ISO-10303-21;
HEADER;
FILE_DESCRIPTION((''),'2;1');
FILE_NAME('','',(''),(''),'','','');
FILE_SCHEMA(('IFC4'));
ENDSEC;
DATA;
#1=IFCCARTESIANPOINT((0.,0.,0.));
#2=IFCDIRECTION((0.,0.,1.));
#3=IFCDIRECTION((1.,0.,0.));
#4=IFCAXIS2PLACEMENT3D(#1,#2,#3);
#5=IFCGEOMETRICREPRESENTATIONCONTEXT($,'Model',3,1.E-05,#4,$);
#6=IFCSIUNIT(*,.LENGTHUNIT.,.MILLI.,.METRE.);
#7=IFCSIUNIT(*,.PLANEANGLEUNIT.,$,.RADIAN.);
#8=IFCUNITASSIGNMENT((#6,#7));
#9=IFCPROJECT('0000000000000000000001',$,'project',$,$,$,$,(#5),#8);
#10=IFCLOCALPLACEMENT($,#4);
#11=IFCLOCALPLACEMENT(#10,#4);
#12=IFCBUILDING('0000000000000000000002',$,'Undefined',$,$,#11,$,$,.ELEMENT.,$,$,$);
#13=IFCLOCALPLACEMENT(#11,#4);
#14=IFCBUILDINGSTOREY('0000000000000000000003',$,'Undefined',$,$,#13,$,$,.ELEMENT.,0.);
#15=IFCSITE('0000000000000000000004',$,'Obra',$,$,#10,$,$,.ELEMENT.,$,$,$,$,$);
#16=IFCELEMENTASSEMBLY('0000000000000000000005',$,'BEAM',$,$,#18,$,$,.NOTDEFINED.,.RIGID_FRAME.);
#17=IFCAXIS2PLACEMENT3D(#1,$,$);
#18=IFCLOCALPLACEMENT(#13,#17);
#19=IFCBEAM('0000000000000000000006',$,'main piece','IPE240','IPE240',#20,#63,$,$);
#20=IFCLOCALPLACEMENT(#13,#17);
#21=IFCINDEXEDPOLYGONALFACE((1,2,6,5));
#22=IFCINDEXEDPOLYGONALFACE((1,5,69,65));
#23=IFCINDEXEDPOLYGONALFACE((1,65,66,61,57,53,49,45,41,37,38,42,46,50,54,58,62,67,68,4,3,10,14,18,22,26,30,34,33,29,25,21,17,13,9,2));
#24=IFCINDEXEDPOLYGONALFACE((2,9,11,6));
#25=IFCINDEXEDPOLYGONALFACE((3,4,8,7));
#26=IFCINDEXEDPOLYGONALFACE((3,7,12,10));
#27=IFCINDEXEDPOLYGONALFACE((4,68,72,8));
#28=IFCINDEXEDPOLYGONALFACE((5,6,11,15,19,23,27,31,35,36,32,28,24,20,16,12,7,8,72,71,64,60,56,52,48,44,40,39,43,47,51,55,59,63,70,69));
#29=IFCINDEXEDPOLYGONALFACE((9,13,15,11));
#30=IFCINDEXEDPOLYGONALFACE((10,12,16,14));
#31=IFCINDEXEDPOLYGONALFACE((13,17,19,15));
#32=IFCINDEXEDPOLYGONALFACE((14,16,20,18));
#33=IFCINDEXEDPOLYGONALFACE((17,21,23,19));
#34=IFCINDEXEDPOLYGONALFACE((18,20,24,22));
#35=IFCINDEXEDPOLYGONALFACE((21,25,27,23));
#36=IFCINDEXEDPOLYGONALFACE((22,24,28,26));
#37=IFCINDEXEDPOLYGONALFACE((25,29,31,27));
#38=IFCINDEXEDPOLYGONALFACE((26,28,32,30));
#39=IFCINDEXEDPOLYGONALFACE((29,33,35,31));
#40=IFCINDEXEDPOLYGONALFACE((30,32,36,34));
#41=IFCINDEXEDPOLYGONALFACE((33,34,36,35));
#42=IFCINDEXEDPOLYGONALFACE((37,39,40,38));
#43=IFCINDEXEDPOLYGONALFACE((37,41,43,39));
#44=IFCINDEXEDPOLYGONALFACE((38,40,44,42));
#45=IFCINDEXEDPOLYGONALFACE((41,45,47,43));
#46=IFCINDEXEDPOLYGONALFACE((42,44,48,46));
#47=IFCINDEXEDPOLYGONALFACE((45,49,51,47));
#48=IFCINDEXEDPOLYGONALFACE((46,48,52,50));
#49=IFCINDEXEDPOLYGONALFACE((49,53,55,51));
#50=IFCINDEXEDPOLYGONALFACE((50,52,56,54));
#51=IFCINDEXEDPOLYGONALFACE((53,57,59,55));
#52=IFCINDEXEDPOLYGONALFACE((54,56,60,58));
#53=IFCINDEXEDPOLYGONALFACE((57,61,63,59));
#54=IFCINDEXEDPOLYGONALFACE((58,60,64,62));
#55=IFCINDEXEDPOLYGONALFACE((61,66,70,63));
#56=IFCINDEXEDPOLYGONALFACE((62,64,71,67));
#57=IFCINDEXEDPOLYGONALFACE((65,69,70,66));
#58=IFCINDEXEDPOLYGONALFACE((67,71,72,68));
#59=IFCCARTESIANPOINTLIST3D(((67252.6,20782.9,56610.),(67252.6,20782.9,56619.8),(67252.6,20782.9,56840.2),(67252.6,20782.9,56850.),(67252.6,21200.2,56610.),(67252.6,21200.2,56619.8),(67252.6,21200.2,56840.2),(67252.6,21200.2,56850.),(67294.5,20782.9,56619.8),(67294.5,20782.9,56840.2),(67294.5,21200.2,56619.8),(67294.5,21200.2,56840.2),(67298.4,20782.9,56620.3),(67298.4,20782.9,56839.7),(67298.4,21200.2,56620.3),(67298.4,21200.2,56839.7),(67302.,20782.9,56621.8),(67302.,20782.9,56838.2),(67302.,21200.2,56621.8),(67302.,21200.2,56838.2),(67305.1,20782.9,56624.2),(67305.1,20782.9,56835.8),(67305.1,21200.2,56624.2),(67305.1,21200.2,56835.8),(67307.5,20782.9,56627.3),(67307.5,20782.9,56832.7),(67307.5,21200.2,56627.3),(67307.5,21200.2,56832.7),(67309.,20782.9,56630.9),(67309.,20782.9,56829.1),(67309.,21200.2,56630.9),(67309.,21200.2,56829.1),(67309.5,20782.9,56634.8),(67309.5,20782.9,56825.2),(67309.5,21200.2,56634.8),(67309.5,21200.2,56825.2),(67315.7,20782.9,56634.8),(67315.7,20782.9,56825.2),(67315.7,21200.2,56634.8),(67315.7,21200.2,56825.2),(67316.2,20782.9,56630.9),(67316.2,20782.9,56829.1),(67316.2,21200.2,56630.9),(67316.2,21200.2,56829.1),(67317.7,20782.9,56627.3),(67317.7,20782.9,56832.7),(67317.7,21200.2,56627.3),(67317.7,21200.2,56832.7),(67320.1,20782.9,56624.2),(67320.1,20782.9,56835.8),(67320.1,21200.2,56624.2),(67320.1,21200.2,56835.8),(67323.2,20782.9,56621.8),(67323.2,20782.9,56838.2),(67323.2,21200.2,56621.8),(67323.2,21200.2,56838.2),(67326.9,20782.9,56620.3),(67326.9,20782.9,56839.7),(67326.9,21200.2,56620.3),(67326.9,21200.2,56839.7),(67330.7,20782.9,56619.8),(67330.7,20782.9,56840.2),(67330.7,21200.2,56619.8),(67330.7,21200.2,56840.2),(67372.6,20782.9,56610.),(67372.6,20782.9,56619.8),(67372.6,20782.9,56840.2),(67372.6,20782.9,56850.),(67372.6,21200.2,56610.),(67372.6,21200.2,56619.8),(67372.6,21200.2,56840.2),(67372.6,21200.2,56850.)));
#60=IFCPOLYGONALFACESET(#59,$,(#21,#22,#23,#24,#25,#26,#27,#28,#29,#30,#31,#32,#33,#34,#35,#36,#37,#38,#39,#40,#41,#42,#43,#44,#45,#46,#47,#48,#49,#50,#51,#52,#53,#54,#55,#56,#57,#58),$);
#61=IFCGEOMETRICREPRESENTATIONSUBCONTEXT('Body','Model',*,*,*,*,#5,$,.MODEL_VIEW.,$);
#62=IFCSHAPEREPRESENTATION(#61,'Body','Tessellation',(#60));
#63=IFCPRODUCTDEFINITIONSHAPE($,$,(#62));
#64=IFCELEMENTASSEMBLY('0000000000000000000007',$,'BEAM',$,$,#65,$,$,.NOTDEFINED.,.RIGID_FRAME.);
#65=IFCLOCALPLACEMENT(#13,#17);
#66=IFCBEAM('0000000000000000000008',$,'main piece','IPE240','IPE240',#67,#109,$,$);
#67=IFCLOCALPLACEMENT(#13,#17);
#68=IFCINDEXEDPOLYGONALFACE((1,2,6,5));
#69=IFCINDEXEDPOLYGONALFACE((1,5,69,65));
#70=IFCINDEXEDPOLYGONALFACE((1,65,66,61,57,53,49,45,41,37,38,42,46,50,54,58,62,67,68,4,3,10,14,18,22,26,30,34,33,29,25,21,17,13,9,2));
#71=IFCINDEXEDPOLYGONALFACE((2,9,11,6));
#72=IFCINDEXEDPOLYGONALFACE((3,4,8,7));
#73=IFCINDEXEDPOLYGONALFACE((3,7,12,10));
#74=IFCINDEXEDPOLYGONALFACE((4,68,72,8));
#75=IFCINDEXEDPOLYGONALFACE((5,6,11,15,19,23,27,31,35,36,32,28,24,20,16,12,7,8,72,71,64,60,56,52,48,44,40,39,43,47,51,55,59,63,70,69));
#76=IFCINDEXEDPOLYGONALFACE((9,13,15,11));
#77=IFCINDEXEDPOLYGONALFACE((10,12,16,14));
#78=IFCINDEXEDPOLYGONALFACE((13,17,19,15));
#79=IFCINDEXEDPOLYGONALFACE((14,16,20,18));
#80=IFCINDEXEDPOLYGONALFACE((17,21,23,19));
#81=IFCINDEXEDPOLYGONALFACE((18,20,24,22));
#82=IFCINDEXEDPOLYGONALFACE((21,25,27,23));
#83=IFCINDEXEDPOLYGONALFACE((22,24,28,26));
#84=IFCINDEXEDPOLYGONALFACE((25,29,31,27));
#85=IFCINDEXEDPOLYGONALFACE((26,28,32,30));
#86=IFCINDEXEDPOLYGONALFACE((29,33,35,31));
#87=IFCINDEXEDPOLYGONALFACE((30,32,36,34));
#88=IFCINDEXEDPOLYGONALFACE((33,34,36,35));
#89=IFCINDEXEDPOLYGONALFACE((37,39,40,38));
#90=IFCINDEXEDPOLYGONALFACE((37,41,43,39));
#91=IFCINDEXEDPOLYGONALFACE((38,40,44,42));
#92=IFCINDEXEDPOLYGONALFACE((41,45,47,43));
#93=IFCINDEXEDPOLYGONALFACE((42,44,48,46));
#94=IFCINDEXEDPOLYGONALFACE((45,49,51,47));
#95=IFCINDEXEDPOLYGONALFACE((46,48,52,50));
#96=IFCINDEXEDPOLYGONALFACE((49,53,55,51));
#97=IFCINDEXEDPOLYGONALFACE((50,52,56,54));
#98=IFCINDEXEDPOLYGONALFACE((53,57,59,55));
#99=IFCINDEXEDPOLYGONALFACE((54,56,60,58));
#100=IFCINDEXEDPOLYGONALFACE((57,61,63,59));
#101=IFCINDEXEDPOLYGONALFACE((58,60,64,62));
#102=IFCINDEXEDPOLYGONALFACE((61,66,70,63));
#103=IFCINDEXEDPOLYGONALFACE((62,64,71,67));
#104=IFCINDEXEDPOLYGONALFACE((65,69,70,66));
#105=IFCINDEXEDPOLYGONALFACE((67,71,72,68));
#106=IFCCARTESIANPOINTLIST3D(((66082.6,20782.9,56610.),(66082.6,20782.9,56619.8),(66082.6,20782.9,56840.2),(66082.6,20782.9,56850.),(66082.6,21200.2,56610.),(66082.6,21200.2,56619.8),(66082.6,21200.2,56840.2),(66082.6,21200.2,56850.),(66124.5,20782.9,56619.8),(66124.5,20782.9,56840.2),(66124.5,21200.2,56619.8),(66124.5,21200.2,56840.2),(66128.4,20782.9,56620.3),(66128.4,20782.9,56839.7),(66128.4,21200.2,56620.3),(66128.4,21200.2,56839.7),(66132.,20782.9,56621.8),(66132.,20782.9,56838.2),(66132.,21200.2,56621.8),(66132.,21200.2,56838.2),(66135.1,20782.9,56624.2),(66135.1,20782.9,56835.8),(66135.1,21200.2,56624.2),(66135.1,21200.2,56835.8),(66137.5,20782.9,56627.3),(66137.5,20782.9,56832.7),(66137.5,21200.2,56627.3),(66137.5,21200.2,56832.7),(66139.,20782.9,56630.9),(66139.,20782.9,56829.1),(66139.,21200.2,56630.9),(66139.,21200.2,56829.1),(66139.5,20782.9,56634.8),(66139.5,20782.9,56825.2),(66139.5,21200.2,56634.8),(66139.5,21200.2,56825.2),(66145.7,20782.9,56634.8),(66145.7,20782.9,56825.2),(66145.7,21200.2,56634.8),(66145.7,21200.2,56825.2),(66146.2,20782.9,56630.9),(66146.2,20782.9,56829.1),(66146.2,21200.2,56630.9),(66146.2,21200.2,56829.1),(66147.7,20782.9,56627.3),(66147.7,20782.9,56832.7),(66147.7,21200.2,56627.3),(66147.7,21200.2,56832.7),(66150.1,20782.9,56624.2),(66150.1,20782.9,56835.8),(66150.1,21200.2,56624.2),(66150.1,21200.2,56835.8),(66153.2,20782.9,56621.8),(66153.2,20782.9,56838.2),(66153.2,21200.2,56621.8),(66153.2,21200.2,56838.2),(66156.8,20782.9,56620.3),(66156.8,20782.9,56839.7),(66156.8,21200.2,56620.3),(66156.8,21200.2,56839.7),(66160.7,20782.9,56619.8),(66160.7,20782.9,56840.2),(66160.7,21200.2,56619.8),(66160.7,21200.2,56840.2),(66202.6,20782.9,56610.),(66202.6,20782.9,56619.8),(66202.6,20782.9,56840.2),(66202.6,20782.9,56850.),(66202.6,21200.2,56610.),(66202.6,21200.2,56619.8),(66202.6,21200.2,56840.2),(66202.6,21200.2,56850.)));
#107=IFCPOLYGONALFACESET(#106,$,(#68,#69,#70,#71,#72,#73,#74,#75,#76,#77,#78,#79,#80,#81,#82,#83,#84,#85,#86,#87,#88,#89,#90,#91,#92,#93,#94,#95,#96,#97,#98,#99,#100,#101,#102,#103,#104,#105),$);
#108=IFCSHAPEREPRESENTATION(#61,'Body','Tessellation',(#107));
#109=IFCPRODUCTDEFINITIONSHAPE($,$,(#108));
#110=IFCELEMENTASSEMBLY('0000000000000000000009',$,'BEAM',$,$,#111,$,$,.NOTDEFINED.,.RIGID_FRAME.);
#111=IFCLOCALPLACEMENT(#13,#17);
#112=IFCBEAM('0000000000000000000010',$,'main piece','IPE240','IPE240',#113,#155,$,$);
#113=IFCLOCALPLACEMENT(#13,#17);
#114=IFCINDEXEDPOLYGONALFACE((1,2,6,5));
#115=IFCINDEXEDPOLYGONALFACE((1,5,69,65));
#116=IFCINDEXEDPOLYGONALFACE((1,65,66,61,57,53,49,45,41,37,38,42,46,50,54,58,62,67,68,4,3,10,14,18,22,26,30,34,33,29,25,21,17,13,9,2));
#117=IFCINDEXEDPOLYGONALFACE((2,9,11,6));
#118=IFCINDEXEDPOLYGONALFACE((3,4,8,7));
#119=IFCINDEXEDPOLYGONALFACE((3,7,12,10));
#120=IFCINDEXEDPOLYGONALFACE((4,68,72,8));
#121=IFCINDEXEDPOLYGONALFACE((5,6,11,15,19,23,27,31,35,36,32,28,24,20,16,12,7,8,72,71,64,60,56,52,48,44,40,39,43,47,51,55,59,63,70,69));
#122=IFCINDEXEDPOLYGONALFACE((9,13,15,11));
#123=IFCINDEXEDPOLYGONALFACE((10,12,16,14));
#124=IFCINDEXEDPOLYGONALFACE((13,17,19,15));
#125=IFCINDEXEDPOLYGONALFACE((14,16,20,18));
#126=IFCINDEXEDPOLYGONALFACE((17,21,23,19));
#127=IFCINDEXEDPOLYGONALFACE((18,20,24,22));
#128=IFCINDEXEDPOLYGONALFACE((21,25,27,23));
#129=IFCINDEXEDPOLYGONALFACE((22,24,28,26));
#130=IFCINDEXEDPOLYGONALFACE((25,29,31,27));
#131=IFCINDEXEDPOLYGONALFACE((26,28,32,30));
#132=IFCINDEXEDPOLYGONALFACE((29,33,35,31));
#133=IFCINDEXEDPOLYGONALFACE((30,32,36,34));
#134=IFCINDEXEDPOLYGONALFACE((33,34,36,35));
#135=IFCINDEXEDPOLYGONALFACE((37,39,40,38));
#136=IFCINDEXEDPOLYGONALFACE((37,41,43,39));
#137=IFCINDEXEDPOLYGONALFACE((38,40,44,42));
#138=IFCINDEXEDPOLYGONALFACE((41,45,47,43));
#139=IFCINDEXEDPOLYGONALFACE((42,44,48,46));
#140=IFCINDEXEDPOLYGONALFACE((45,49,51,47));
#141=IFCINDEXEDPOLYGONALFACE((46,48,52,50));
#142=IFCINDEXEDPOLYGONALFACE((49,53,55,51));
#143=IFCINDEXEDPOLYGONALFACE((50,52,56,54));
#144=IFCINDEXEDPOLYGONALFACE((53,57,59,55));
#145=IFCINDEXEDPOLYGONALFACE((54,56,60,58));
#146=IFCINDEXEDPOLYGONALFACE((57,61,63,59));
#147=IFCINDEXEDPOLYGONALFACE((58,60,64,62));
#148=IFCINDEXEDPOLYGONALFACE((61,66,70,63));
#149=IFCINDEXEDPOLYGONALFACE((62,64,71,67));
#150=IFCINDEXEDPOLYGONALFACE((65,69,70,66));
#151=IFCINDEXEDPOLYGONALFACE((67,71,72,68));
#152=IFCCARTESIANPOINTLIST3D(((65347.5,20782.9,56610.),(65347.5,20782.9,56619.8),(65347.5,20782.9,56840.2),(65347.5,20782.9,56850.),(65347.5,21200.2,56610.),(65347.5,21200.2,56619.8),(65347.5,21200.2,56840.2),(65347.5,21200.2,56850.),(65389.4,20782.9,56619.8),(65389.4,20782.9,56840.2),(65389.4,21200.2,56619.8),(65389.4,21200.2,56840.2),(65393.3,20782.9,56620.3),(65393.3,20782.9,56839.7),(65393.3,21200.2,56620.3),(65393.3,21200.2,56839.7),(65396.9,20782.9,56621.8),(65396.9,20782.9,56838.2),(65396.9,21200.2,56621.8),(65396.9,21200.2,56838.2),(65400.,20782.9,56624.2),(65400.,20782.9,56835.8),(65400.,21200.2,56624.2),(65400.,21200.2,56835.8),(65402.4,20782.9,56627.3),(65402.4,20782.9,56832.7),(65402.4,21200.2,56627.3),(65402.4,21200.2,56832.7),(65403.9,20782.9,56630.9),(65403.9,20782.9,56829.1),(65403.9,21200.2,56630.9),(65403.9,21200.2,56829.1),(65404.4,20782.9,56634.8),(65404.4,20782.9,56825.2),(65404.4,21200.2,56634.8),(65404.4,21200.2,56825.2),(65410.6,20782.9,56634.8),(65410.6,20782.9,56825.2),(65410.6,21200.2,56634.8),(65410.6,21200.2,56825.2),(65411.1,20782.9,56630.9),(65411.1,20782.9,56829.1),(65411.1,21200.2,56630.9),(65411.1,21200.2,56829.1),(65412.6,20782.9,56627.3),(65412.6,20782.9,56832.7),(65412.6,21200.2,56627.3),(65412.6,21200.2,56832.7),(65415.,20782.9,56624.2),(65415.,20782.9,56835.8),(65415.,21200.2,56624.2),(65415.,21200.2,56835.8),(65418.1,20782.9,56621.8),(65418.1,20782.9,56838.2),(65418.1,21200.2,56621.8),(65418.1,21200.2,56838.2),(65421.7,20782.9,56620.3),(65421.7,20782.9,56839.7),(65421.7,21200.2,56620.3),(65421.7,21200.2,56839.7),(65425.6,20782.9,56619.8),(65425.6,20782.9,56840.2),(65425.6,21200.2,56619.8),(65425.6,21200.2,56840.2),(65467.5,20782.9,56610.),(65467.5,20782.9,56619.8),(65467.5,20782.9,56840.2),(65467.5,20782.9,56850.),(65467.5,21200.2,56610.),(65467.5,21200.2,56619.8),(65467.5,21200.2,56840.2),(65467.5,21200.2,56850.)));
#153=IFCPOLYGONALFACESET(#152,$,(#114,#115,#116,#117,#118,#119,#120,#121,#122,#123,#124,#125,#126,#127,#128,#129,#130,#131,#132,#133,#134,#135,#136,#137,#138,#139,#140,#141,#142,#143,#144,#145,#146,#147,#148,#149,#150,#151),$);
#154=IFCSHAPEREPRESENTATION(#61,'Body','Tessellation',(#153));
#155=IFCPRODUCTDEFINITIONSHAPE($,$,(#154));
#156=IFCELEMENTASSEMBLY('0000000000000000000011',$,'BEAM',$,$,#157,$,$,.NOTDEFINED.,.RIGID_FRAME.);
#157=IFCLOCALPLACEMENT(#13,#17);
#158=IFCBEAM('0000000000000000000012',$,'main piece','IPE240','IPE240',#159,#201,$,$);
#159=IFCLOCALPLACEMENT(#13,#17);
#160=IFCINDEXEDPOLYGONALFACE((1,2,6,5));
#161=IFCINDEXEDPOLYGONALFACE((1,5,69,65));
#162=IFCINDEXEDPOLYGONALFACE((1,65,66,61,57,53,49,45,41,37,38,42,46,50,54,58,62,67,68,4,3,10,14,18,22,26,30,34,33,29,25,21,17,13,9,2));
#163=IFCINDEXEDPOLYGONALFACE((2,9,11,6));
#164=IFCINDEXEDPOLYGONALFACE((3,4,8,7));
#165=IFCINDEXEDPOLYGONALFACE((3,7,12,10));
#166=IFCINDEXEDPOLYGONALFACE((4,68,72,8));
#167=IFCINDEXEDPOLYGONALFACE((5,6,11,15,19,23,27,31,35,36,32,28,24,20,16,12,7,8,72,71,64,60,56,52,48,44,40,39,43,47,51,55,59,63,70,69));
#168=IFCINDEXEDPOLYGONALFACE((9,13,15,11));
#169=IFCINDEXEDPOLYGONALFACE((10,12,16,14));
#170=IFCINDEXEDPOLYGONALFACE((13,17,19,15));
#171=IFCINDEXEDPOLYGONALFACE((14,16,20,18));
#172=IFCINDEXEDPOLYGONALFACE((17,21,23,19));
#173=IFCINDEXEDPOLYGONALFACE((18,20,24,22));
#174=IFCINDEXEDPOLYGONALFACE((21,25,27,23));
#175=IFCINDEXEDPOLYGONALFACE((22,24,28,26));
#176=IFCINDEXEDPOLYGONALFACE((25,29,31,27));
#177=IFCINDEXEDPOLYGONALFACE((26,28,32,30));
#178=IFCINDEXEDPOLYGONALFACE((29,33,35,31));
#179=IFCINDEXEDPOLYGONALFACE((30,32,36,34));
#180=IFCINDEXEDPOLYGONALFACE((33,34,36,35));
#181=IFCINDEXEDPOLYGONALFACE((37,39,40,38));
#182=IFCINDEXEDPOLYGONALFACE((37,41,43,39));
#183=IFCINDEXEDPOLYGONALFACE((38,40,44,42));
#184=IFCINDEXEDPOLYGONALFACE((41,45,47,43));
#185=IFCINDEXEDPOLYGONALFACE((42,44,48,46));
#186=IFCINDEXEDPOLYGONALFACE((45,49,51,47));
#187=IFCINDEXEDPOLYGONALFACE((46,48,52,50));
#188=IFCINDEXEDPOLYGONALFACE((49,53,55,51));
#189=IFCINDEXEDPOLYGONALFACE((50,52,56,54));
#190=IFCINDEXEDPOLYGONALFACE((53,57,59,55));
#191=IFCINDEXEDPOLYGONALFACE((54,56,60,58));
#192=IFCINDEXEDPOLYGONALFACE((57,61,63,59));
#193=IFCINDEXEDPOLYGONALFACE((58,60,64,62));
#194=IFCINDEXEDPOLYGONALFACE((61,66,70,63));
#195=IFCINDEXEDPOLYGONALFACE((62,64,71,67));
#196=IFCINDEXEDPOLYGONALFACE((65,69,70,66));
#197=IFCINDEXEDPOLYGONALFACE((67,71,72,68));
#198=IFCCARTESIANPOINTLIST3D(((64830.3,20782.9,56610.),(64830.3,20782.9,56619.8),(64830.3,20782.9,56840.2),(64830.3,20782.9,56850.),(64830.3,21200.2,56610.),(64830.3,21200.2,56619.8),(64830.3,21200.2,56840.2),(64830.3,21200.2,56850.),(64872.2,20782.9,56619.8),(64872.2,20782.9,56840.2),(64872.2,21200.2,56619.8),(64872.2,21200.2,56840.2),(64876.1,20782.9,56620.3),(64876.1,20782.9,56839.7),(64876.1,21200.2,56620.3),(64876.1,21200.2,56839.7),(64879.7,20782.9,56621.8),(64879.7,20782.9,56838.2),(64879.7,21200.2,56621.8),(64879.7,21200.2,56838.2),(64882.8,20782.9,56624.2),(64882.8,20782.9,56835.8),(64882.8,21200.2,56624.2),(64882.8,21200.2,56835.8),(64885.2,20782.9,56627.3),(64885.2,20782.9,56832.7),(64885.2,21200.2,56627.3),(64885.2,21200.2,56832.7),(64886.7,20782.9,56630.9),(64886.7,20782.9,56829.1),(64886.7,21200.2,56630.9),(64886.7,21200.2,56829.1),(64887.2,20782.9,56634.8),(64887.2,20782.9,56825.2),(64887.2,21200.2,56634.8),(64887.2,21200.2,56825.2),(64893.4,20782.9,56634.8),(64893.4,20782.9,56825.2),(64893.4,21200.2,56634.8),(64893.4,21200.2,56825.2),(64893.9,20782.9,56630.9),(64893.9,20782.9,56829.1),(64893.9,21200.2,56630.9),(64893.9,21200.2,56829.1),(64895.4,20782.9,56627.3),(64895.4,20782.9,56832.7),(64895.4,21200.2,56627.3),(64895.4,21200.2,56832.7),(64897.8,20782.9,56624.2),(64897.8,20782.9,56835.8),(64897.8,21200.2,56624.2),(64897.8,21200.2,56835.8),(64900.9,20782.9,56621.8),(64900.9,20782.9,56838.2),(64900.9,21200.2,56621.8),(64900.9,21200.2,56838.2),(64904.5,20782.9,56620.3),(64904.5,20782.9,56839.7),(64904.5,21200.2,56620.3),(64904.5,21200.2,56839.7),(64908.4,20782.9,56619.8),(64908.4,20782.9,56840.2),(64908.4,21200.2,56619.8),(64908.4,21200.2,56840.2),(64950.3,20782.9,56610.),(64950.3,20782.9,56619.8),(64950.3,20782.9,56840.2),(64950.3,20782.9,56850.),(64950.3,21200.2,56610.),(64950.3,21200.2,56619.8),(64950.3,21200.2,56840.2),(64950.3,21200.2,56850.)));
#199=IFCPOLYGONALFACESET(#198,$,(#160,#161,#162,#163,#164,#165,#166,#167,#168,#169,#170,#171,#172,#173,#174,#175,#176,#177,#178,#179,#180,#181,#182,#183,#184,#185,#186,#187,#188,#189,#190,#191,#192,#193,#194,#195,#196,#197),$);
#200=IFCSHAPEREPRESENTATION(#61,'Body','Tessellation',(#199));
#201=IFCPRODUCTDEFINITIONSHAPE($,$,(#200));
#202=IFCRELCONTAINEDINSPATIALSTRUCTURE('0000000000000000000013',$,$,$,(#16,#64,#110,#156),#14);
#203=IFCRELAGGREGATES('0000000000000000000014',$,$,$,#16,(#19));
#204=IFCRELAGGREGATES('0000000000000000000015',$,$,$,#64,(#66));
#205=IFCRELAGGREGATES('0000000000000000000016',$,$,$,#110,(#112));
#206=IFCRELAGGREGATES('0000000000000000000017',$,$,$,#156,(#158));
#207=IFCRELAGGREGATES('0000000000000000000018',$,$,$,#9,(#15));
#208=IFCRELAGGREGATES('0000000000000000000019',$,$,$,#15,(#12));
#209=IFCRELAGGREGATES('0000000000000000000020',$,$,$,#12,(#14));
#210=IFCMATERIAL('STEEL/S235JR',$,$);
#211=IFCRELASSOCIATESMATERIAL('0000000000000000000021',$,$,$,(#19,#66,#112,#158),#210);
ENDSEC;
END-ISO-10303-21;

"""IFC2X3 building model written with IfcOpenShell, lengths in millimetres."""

from ifc_helpers import new_model, si_unit, frame, origin_with_axes, origin_2d_with_axis, place, context, subcontext, project, spatial, i_section, extrude, material, element, aggregate, save


model = new_model("IFC2X3")

# Units and contexts
model_context = context("Model", 3, precision=1e-05, world=origin_with_axes())
body_context = subcontext(model_context, "Body", "Model", "MODEL_VIEW")
ifc_project = project(units=[si_unit("LENGTHUNIT", "METRE", prefix="MILLI"), si_unit("PLANEANGLEUNIT", "RADIAN")], contexts=[model_context])

# Site, building, storey
site_placement = place(None, origin_with_axes())
site = spatial("IfcSite", under=ifc_project, at=site_placement, Name="Obra", CompositionType="ELEMENT")
building_placement = place(site_placement, origin_with_axes())
building = spatial("IfcBuilding", under=site, at=building_placement, Name="Undefined", CompositionType="ELEMENT")
storey_placement = place(building_placement, origin_with_axes())
storey = spatial("IfcBuildingStorey", under=building, at=storey_placement, Name="Undefined", CompositionType="ELEMENT", Elevation=0.0)

# Shared definitions
ifc_material_1 = material(Name="STEEL/S235JR")

# Element assemblies, beams
assembly_1_placement = place(storey_placement, origin_with_axes())
assembly_1 = element("IfcElementAssembly", 1, at=assembly_1_placement, inside=storey, Name="BEAM", AssemblyPlace="NOTDEFINED", PredefinedType="RIGID_FRAME")
beam_1_placement = place(assembly_1_placement, frame((67312.6, 20782.9, 56730.0), z_axis=(0.0, 0.0, 1.0), x_axis=(0.0, 1.0, 0.0)))
beam_1 = element("IfcBeam", 2, at=beam_1_placement, material=ifc_material_1, Name="main piece", Description="IPE240", ObjectType="IPE240", context=body_context, shape_type="SweptSolid", body=[
    extrude(i_section(OverallWidth=120.0, OverallDepth=240.0, WebThickness=6.2, FlangeThickness=9.8, FilletRadius=15.0, at=origin_2d_with_axis()), frame((417.2, 0.0, 0.0), z_axis=(-1.0, 0.0, 0.0), x_axis=(0.0, -1.0, 0.0)), (0.0, 0.0, 1.0), 417.2),
])
aggregate(assembly_1, [beam_1])
assembly_2_placement = place(storey_placement, origin_with_axes())
assembly_2 = element("IfcElementAssembly", 3, at=assembly_2_placement, inside=storey, Name="BEAM", AssemblyPlace="NOTDEFINED", PredefinedType="RIGID_FRAME")
beam_2_placement = place(assembly_2_placement, frame((66142.6, 20782.9, 56730.0), z_axis=(0.0, 0.0, 1.0), x_axis=(0.0, 1.0, 0.0)))
beam_2 = element("IfcBeam", 4, at=beam_2_placement, material=ifc_material_1, Name="main piece", Description="IPE240", ObjectType="IPE240", context=body_context, shape_type="SweptSolid", body=[
    extrude(i_section(OverallWidth=120.0, OverallDepth=240.0, WebThickness=6.2, FlangeThickness=9.8, FilletRadius=15.0, at=origin_2d_with_axis()), frame((417.2, 0.0, 0.0), z_axis=(-1.0, 0.0, 0.0), x_axis=(0.0, -1.0, 0.0)), (0.0, 0.0, 1.0), 417.2),
])
aggregate(assembly_2, [beam_2])
assembly_3_placement = place(storey_placement, origin_with_axes())
assembly_3 = element("IfcElementAssembly", 5, at=assembly_3_placement, inside=storey, Name="BEAM", AssemblyPlace="NOTDEFINED", PredefinedType="RIGID_FRAME")
beam_3_placement = place(assembly_3_placement, frame((65407.5, 20782.9, 56730.0), z_axis=(0.0, 0.0, 1.0), x_axis=(0.0, 1.0, 0.0)))
beam_3 = element("IfcBeam", 6, at=beam_3_placement, material=ifc_material_1, Name="main piece", Description="IPE240", ObjectType="IPE240", context=body_context, shape_type="SweptSolid", body=[
    extrude(i_section(OverallWidth=120.0, OverallDepth=240.0, WebThickness=6.2, FlangeThickness=9.8, FilletRadius=15.0, at=origin_2d_with_axis()), frame((417.2, 0.0, 0.0), z_axis=(-1.0, 0.0, 0.0), x_axis=(0.0, -1.0, 0.0)), (0.0, 0.0, 1.0), 417.2),
])
aggregate(assembly_3, [beam_3])
assembly_4_placement = place(storey_placement, origin_with_axes())
assembly_4 = element("IfcElementAssembly", 7, at=assembly_4_placement, inside=storey, Name="BEAM", AssemblyPlace="NOTDEFINED", PredefinedType="RIGID_FRAME")
beam_4_placement = place(assembly_4_placement, frame((64890.3, 20782.9, 56730.0), z_axis=(0.0, 0.0, 1.0), x_axis=(0.0, 1.0, 0.0)))
beam_4 = element("IfcBeam", 8, at=beam_4_placement, material=ifc_material_1, Name="main piece", Description="IPE240", ObjectType="IPE240", context=body_context, shape_type="SweptSolid", body=[
    extrude(i_section(OverallWidth=120.0, OverallDepth=240.0, WebThickness=6.2, FlangeThickness=9.8, FilletRadius=15.0, at=origin_2d_with_axis()), frame((417.2, 0.0, 0.0), z_axis=(-1.0, 0.0, 0.0), x_axis=(0.0, -1.0, 0.0)), (0.0, 0.0, 1.0), 417.2),
])
aggregate(assembly_4, [beam_4])

save(model, "model.ifc")
